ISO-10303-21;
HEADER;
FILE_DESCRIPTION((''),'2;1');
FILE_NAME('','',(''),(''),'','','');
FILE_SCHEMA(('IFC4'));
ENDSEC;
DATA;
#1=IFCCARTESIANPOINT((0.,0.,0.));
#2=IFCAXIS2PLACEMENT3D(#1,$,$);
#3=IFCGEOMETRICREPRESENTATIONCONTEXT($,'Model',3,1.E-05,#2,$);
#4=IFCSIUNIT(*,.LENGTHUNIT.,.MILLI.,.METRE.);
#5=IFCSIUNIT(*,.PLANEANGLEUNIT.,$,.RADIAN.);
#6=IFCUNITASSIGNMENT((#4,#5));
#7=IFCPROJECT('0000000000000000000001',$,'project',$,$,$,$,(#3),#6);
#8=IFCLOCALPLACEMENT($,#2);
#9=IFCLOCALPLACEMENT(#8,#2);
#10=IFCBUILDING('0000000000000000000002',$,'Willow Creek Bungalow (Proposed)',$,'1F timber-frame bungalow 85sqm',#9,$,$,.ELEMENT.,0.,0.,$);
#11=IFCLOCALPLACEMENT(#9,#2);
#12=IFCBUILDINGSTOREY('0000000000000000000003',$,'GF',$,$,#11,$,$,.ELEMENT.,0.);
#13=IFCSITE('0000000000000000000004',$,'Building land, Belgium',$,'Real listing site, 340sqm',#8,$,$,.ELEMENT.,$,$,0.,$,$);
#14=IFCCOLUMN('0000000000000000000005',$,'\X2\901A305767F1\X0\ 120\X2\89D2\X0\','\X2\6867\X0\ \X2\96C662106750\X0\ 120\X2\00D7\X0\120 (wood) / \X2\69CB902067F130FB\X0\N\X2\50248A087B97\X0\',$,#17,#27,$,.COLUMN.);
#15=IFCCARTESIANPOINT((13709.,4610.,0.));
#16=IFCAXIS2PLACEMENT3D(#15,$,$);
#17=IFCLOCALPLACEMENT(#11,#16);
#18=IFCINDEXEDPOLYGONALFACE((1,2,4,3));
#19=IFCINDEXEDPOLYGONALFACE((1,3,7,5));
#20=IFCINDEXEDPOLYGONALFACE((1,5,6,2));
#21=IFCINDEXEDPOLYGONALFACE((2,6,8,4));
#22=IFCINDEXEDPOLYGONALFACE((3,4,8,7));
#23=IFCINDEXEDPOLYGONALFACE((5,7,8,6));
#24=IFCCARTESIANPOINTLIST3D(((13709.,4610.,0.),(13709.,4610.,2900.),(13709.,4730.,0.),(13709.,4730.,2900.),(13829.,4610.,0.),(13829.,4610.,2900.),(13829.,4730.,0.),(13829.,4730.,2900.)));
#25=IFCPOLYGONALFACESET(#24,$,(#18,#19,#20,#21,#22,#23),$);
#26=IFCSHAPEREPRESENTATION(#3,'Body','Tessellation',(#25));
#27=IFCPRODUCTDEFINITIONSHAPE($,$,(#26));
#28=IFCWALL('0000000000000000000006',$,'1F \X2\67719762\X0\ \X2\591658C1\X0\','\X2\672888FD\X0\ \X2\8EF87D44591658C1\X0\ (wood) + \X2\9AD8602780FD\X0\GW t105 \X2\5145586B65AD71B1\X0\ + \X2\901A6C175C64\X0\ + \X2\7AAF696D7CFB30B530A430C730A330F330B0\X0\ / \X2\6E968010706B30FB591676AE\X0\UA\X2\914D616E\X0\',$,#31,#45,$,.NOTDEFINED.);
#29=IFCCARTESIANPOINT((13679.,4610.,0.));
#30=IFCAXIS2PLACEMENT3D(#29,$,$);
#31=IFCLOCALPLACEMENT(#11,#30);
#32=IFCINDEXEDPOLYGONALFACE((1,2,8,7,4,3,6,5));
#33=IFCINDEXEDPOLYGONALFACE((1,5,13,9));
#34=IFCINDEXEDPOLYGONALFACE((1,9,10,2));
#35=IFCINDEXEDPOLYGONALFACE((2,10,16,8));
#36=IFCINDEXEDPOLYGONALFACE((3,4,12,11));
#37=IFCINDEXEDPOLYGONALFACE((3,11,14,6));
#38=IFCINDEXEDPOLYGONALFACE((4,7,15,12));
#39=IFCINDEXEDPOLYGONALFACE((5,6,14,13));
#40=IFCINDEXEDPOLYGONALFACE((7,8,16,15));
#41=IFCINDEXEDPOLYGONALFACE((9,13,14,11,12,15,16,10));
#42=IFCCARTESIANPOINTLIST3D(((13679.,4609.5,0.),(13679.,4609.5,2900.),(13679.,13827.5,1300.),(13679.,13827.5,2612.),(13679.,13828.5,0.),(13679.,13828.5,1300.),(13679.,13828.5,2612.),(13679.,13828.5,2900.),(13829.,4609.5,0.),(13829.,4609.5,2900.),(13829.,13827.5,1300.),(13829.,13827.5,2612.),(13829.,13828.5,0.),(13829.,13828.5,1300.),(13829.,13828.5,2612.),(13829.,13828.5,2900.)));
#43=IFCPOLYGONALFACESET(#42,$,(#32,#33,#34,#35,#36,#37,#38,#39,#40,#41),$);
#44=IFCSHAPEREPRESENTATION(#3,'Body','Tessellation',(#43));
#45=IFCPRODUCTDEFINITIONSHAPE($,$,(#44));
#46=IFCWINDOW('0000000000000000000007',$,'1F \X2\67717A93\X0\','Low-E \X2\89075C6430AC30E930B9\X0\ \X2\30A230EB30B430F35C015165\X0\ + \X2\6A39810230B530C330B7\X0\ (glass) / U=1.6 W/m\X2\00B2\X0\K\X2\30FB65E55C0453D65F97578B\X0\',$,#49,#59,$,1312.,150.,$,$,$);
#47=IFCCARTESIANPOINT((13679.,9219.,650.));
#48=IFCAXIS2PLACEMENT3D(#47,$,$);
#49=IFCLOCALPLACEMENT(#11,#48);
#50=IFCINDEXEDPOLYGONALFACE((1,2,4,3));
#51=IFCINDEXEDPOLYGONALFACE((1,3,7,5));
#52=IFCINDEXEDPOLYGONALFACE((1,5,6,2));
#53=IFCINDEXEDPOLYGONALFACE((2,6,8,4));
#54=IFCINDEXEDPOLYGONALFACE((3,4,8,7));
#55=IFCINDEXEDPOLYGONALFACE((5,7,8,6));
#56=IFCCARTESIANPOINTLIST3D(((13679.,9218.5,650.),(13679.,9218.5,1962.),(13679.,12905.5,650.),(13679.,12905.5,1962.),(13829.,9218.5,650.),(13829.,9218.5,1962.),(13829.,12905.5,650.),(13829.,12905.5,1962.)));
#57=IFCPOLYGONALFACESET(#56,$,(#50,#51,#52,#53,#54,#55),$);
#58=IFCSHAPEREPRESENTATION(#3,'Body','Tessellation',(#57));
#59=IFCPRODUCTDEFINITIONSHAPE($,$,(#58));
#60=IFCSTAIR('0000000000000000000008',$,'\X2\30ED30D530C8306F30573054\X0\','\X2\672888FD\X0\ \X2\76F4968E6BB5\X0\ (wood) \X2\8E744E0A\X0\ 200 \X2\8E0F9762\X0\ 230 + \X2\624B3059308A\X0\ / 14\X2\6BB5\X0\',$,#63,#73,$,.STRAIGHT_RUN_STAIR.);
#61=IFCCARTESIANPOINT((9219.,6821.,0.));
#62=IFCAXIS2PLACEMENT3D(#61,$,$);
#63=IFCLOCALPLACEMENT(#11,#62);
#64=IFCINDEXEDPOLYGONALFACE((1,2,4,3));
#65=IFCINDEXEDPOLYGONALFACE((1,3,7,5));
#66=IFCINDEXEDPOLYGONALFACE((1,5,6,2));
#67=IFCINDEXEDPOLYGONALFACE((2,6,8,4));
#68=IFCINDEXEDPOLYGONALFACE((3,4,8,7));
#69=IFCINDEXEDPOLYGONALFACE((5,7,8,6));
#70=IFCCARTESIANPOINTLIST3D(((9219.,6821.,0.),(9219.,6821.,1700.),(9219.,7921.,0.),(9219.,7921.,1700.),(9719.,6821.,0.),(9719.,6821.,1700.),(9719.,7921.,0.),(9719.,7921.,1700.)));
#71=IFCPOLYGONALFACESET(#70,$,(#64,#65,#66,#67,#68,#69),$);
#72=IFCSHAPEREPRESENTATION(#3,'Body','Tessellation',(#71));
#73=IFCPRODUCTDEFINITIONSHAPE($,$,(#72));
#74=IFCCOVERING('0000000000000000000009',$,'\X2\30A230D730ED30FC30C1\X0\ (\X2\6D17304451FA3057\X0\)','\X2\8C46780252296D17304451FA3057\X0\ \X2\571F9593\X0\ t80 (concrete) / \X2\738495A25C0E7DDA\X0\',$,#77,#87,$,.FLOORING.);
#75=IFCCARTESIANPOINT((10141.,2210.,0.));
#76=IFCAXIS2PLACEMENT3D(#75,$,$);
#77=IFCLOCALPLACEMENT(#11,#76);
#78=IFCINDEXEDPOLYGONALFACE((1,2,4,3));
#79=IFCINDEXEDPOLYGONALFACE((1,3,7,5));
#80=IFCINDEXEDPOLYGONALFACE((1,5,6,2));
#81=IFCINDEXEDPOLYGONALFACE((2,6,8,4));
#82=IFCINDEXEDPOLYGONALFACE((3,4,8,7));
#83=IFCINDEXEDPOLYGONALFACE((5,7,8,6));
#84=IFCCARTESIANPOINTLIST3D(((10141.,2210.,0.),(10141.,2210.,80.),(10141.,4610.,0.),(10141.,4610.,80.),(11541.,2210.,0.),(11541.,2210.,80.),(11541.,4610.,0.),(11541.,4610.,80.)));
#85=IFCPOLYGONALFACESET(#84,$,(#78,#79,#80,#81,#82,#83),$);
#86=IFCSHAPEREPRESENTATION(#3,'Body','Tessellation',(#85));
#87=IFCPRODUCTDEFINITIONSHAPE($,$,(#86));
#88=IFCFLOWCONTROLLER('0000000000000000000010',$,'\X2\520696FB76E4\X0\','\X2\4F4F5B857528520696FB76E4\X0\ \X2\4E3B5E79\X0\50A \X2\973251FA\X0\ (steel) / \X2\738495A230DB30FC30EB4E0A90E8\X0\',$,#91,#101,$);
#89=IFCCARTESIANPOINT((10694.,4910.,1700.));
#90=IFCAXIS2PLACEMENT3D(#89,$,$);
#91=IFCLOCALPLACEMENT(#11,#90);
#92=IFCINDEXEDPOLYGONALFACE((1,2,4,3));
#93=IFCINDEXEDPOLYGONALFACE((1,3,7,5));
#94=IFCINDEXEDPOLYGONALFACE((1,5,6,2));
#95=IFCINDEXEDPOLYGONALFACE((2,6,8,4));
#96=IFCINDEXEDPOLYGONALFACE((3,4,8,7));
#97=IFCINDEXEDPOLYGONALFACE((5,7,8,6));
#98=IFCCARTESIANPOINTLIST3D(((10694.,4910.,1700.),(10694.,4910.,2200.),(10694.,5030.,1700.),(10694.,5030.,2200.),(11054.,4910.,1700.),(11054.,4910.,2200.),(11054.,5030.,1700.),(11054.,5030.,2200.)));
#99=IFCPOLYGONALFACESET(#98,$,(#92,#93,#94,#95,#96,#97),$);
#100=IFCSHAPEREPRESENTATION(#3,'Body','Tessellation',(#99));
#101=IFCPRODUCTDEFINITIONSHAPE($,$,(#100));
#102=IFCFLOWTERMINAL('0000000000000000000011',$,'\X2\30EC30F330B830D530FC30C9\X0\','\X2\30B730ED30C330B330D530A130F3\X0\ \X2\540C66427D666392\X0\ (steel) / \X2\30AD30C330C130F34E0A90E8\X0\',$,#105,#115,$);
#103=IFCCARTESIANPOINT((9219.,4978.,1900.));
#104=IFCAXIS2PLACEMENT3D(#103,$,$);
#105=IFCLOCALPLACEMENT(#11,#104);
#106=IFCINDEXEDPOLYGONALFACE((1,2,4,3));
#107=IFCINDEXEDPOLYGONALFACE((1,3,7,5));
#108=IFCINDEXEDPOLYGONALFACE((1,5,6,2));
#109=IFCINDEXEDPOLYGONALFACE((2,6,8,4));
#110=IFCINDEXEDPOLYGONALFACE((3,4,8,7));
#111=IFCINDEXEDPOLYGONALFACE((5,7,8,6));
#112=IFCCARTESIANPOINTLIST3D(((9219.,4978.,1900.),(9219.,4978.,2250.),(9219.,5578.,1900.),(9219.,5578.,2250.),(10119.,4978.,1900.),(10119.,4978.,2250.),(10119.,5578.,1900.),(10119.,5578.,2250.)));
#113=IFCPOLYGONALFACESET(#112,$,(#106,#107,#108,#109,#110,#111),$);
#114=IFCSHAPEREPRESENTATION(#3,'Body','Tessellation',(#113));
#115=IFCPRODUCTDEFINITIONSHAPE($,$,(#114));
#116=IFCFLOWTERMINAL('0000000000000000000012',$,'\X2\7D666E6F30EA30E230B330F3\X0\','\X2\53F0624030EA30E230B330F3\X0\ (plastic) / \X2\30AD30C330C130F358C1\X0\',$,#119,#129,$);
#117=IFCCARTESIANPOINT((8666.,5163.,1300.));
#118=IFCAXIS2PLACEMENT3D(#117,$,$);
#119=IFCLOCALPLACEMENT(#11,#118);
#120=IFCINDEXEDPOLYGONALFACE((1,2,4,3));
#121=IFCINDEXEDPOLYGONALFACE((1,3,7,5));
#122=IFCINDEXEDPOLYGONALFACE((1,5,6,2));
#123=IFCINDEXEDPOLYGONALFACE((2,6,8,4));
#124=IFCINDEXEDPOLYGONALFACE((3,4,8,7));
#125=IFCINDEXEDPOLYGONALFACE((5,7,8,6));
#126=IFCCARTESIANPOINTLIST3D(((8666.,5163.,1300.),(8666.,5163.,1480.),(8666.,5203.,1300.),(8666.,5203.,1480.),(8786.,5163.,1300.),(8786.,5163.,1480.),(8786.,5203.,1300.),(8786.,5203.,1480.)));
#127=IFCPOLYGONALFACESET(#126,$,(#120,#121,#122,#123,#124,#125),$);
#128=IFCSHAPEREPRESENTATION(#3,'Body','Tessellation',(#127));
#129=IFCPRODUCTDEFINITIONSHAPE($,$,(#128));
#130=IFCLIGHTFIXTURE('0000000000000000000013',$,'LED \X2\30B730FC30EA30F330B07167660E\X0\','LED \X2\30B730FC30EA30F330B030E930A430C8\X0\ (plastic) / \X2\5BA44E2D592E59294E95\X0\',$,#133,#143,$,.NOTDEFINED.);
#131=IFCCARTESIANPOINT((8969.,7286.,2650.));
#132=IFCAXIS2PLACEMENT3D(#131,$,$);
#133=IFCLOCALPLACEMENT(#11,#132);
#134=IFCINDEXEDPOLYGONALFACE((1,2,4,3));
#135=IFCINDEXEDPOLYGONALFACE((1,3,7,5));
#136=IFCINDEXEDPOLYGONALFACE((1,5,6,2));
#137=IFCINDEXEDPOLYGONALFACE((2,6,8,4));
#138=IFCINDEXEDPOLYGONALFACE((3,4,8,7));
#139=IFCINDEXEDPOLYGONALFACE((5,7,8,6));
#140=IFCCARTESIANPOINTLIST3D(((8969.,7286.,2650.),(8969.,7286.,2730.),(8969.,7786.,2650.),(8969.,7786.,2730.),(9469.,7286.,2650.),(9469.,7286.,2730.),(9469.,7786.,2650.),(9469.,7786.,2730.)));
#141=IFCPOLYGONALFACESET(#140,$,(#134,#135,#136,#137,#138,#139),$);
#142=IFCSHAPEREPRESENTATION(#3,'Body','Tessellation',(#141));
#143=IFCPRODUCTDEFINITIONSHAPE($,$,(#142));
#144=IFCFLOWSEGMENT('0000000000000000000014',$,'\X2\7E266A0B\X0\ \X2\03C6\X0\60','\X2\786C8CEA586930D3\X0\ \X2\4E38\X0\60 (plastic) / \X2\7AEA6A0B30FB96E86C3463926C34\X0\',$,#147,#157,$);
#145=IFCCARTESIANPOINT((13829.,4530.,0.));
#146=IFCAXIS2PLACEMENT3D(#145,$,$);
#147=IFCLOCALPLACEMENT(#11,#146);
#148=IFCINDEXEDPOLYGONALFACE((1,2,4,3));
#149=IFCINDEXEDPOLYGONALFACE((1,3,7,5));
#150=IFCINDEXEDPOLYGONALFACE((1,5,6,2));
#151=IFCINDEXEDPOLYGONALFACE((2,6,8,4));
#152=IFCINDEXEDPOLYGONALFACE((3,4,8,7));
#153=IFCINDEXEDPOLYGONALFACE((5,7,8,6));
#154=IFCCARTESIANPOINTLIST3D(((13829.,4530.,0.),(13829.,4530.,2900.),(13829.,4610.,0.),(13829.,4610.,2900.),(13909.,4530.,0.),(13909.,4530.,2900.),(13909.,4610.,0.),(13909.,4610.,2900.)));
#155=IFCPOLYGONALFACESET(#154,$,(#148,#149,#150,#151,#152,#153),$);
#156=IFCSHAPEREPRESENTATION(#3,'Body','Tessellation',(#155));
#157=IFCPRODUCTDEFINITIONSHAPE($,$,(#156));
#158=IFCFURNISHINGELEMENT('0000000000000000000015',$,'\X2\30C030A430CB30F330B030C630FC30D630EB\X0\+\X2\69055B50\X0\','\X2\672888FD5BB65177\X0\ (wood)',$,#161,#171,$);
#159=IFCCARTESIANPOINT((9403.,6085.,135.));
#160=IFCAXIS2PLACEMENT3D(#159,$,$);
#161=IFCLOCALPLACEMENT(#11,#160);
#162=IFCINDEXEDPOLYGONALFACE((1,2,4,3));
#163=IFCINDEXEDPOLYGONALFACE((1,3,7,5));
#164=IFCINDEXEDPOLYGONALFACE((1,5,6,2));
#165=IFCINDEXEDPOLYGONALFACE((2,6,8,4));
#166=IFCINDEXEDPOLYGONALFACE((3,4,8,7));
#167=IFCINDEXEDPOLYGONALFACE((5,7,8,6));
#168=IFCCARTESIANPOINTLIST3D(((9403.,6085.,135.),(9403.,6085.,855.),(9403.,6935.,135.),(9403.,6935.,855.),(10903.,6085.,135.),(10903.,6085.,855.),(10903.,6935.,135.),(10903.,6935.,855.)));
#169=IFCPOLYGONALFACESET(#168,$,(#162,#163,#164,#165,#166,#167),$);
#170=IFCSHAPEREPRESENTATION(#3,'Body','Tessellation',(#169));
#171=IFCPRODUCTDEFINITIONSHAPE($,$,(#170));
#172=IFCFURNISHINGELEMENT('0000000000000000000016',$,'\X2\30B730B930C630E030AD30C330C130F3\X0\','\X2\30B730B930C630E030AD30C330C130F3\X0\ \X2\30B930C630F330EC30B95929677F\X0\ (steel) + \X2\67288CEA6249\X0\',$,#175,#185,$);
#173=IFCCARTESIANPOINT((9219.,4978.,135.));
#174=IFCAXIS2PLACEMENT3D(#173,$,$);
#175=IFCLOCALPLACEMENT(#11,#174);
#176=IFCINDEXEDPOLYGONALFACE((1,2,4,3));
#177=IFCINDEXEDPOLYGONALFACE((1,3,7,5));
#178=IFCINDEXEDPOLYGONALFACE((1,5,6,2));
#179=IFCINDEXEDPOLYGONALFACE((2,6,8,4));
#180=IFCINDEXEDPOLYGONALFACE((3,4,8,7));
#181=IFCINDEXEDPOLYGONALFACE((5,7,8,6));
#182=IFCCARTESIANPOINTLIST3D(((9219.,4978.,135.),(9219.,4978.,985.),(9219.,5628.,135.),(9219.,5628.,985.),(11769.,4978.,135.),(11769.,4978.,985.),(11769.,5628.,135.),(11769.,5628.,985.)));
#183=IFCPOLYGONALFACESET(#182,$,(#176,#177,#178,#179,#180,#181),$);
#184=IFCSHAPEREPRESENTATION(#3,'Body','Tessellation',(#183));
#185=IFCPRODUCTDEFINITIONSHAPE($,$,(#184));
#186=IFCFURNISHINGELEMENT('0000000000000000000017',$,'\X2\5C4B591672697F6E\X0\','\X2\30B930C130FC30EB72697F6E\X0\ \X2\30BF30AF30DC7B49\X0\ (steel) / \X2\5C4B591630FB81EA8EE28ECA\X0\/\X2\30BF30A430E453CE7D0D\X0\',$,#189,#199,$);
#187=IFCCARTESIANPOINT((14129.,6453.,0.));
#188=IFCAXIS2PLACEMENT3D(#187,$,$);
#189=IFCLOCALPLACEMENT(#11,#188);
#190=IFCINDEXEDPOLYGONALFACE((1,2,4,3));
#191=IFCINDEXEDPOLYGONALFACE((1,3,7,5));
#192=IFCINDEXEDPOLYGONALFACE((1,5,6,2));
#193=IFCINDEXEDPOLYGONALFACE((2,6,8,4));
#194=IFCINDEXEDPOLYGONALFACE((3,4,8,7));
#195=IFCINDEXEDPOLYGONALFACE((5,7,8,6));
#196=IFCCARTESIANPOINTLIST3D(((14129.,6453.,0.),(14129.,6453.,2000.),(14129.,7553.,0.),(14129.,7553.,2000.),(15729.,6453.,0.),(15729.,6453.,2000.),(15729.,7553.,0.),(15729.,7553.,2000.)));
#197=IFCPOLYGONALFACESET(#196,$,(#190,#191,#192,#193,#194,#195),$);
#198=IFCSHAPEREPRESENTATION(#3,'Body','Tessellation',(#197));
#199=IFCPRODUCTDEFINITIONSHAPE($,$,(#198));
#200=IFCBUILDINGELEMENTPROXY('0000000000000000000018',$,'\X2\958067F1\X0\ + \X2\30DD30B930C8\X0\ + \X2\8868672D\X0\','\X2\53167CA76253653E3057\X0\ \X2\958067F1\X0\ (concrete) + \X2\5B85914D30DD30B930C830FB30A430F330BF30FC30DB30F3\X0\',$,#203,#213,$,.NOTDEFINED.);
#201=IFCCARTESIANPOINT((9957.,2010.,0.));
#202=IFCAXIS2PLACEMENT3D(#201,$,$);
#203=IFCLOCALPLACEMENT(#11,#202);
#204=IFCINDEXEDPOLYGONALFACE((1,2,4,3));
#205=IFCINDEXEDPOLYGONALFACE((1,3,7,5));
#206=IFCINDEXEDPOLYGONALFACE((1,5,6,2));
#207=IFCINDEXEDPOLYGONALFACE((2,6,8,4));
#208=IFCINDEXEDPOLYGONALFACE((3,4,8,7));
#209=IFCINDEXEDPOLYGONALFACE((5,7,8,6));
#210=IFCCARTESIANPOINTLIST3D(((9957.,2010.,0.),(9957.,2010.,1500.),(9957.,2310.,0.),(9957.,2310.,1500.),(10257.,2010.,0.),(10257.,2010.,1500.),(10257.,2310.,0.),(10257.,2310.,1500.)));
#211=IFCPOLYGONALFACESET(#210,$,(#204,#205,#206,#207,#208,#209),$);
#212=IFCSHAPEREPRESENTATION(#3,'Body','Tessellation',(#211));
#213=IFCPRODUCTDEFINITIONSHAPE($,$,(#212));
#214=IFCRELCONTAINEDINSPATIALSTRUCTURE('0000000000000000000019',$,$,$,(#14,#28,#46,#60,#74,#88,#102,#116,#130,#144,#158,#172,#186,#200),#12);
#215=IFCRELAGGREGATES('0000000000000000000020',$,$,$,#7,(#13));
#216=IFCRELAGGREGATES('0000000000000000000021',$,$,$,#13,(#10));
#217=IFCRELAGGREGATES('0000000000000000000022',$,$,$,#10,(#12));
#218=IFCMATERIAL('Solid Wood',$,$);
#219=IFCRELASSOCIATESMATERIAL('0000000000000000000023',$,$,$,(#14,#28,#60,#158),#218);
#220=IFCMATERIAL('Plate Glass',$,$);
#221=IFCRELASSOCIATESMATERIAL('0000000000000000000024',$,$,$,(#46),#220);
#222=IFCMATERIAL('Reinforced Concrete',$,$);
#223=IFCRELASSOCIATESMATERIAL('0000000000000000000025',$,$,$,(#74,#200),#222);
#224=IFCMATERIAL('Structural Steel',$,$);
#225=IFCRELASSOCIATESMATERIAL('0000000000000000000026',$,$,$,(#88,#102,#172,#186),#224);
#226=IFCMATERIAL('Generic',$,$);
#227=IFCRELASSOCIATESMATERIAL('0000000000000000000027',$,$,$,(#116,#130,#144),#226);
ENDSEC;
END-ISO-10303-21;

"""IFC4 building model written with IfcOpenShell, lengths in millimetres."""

from ifc_helpers import new_model, si_unit, frame, frame_2d, origin, place, context, project, spatial, rectangle, extrude, material, element, fill, save


model = new_model("IFC4")

# Units and contexts
model_context = context("Model", 3, precision=1e-05, world=origin())
ifc_project = project(units=[si_unit("LENGTHUNIT", "METRE", prefix="MILLI"), si_unit("PLANEANGLEUNIT", "RADIAN")], contexts=[model_context])

# Site, building, storey
site_placement = place(None, origin())
site = spatial("IfcSite", under=ifc_project, at=site_placement, Name="Building land, Belgium", ObjectType="Real listing site, 340sqm", CompositionType="ELEMENT", RefElevation=0.0)
building_placement = place(site_placement, origin())
building = spatial("IfcBuilding", under=site, at=building_placement, Name="Willow Creek Bungalow (Proposed)", ObjectType="1F timber-frame bungalow 85sqm", CompositionType="ELEMENT", ElevationOfRefHeight=0.0, ElevationOfTerrain=0.0)
storey_placement = place(building_placement, origin())
storey = spatial("IfcBuildingStorey", under=building, at=storey_placement, Name="GF", CompositionType="ELEMENT", Elevation=0.0)

# Column
ifc_material_1 = material(Name="Solid Wood")
column_1_placement = place(storey_placement, frame((13709.0, 4610.0, 0.0)))
element("IfcColumn", 1, at=column_1_placement, inside=storey, material=ifc_material_1, Name="通し柱 120角", Description="桧 集成材 120×120 (wood) / 構造柱・N値計算", PredefinedType="COLUMN", context=model_context, shape_type="SweptSolid", body=[
    extrude(rectangle(XDim=120.0, YDim=120.0, at=frame_2d((60.0, 60.0))), frame((13709.0, 4610.0, 0.0)), (0.0, 0.0, 1.0), 2900.0),
])

# Wall, opening, window
wall_1_placement = place(storey_placement, frame((13679.0, 4610.0, 0.0)))
wall_1 = element("IfcWall", 2, at=wall_1_placement, inside=storey, material=ifc_material_1, Name="1F 東面 外壁", Description="木製 軸組外壁 (wood) + 高性能GW t105 充填断熱 + 通気層 + 窯業系サイディング / 準耐火・外皮UA配慮", PredefinedType="NOTDEFINED", context=model_context, shape_type="SweptSolid", body=[
    extrude(rectangle(XDim=150.0, YDim=9219.0, at=frame_2d((75.0, 4609.0))), frame((13679.0, 4610.0, 0.0)), (0.0, 0.0, 1.0), 2900.0),
])
opening_placement = place(storey_placement, frame((13679.0, 9219.0, 650.0)))
opening = element("IfcOpeningElement", 3, at=opening_placement, cuts=wall_1, PredefinedType="NOTDEFINED", context=model_context, shape_type="SweptSolid", body=[
    extrude(rectangle(XDim=150.0, YDim=3687.0, at=frame_2d((75.0, 1843.0))), frame((13679.0, 9219.0, 650.0)), (0.0, 0.0, 1.0), 1312.0),
])
ifc_material_2 = material(Name="Plate Glass")
window_placement = place(storey_placement, frame((13679.0, 9219.0, 650.0)))
window = element("IfcWindow", 4, at=window_placement, inside=storey, material=ifc_material_2, Name="1F 東窓", Description="Low-E 複層ガラス アルゴン封入 + 樹脂サッシ (glass) / U=1.6 W/m²K・日射取得型", OverallHeight=1312.0, OverallWidth=150.0, context=model_context, shape_type="SweptSolid", body=[
    extrude(rectangle(XDim=150.0, YDim=3687.0, at=frame_2d((75.0, 1843.0))), frame((13679.0, 9219.0, 650.0)), (0.0, 0.0, 1.0), 1312.0),
])
fill(opening, window)

# Stair
stair_placement = place(storey_placement, frame((9219.0, 6821.0, 0.0)))
element("IfcStair", 5, at=stair_placement, inside=storey, material=ifc_material_1, Name="ロフトはしご", Description="木製 直階段 (wood) 蹴上 200 踏面 230 + 手すり / 14段", PredefinedType="STRAIGHT_RUN_STAIR", context=model_context, shape_type="SweptSolid", body=[
    extrude(rectangle(XDim=500.0, YDim=1100.0, at=frame_2d((250.0, 550.0))), frame((9219.0, 6821.0, 0.0)), (0.0, 0.0, 1.0), 1700.0),
])

# Covering
ifc_material_3 = material(Name="Reinforced Concrete")
covering_placement = place(storey_placement, frame((10141.0, 2210.0, 0.0)))
element("IfcCovering", 6, at=covering_placement, inside=storey, material=ifc_material_3, Name="アプローチ (洗い出し)", Description="豆砂利洗い出し 土間 t80 (concrete) / 玄関導線", PredefinedType="FLOORING", context=model_context, shape_type="SweptSolid", body=[
    extrude(rectangle(XDim=1400.0, YDim=2400.0, at=frame_2d((700.0, 1200.0))), frame((10141.0, 2210.0, 0.0)), (0.0, 0.0, 1.0), 80.0),
])

# Flow controller
ifc_material_4 = material(Name="Structural Steel")
flow_controller_placement = place(storey_placement, frame((10694.0, 4910.0, 1700.0)))
element("IfcFlowController", 7, at=flow_controller_placement, inside=storey, material=ifc_material_4, Name="分電盤", Description="住宅用分電盤 主幹50A 露出 (steel) / 玄関ホール上部", context=model_context, shape_type="SweptSolid", body=[
    extrude(rectangle(XDim=360.0, YDim=120.0, at=frame_2d((180.0, 60.0))), frame((10694.0, 4910.0, 1700.0)), (0.0, 0.0, 1.0), 500.0),
])

# Flow terminals
flow_terminal_1_placement = place(storey_placement, frame((9219.0, 4978.0, 1900.0)))
element("IfcFlowTerminal", 8, at=flow_terminal_1_placement, inside=storey, material=ifc_material_4, Name="レンジフード", Description="シロッコファン 同時給排 (steel) / キッチン上部", context=model_context, shape_type="SweptSolid", body=[
    extrude(rectangle(XDim=900.0, YDim=600.0, at=frame_2d((450.0, 300.0))), frame((9219.0, 4978.0, 1900.0)), (0.0, 0.0, 1.0), 350.0),
])
ifc_material_5 = material(Name="Generic")
flow_terminal_2_placement = place(storey_placement, frame((8666.0, 5163.0, 1300.0)))
element("IfcFlowTerminal", 9, at=flow_terminal_2_placement, inside=storey, material=ifc_material_5, Name="給湯リモコン", Description="台所リモコン (plastic) / キッチン壁", context=model_context, shape_type="SweptSolid", body=[
    extrude(rectangle(XDim=120.0, YDim=40.0, at=frame_2d((60.0, 20.0))), frame((8666.0, 5163.0, 1300.0)), (0.0, 0.0, 1.0), 180.0),
])

# Light fixture
light_fixture_placement = place(storey_placement, frame((8969.0, 7286.0, 2650.0)))
element("IfcLightFixture", 10, at=light_fixture_placement, inside=storey, material=ifc_material_5, Name="LED シーリング照明", Description="LED シーリングライト (plastic) / 室中央天井", PredefinedType="NOTDEFINED", context=model_context, shape_type="SweptSolid", body=[
    extrude(rectangle(XDim=500.0, YDim=500.0, at=frame_2d((250.0, 250.0))), frame((8969.0, 7286.0, 2650.0)), (0.0, 0.0, 1.0), 80.0),
])

# Flow segment
flow_segment_placement = place(storey_placement, frame((13829.0, 4530.0, 0.0)))
element("IfcFlowSegment", 11, at=flow_segment_placement, inside=storey, material=ifc_material_5, Name="縦樋 φ60", Description="硬質塩ビ 丸60 (plastic) / 竪樋・雨水排水", context=model_context, shape_type="SweptSolid", body=[
    extrude(rectangle(XDim=80.0, YDim=80.0, at=frame_2d((40.0, 40.0))), frame((13829.0, 4530.0, 0.0)), (0.0, 0.0, 1.0), 2900.0),
])

# Furnishing elements
furnishing_1_placement = place(storey_placement, frame((9403.0, 6085.0, 135.0)))
element("IfcFurnishingElement", 12, at=furnishing_1_placement, inside=storey, material=ifc_material_1, Name="ダイニングテーブル+椅子", Description="木製家具 (wood)", context=model_context, shape_type="SweptSolid", body=[
    extrude(rectangle(XDim=1500.0, YDim=850.0, at=frame_2d((750.0, 425.0))), frame((9403.0, 6085.0, 135.0)), (0.0, 0.0, 1.0), 720.0),
])
furnishing_2_placement = place(storey_placement, frame((9219.0, 4978.0, 135.0)))
element("IfcFurnishingElement", 13, at=furnishing_2_placement, inside=storey, material=ifc_material_4, Name="システムキッチン", Description="システムキッチン ステンレス天板 (steel) + 木質扉", context=model_context, shape_type="SweptSolid", body=[
    extrude(rectangle(XDim=2550.0, YDim=650.0, at=frame_2d((1275.0, 325.0))), frame((9219.0, 4978.0, 135.0)), (0.0, 0.0, 1.0), 850.0),
])
furnishing_3_placement = place(storey_placement, frame((14129.0, 6453.0, 0.0)))
element("IfcFurnishingElement", 14, at=furnishing_3_placement, inside=storey, material=ifc_material_4, Name="屋外物置", Description="スチール物置 タクボ等 (steel) / 屋外・自転車/タイヤ収納", context=model_context, shape_type="SweptSolid", body=[
    extrude(rectangle(XDim=1600.0, YDim=1100.0, at=frame_2d((800.0, 550.0))), frame((14129.0, 6453.0, 0.0)), (0.0, 0.0, 1.0), 2000.0),
])

# Building element proxy
proxy_placement = place(storey_placement, frame((9957.0, 2010.0, 0.0)))
element("IfcBuildingElementProxy", 15, at=proxy_placement, inside=storey, material=ifc_material_3, Name="門柱 + ポスト + 表札", Description="化粧打放し 門柱 (concrete) + 宅配ポスト・インターホン", PredefinedType="NOTDEFINED", context=model_context, shape_type="SweptSolid", body=[
    extrude(rectangle(XDim=300.0, YDim=300.0, at=frame_2d((150.0, 150.0))), frame((9957.0, 2010.0, 0.0)), (0.0, 0.0, 1.0), 1500.0),
])

save(model, "model.ifc")
